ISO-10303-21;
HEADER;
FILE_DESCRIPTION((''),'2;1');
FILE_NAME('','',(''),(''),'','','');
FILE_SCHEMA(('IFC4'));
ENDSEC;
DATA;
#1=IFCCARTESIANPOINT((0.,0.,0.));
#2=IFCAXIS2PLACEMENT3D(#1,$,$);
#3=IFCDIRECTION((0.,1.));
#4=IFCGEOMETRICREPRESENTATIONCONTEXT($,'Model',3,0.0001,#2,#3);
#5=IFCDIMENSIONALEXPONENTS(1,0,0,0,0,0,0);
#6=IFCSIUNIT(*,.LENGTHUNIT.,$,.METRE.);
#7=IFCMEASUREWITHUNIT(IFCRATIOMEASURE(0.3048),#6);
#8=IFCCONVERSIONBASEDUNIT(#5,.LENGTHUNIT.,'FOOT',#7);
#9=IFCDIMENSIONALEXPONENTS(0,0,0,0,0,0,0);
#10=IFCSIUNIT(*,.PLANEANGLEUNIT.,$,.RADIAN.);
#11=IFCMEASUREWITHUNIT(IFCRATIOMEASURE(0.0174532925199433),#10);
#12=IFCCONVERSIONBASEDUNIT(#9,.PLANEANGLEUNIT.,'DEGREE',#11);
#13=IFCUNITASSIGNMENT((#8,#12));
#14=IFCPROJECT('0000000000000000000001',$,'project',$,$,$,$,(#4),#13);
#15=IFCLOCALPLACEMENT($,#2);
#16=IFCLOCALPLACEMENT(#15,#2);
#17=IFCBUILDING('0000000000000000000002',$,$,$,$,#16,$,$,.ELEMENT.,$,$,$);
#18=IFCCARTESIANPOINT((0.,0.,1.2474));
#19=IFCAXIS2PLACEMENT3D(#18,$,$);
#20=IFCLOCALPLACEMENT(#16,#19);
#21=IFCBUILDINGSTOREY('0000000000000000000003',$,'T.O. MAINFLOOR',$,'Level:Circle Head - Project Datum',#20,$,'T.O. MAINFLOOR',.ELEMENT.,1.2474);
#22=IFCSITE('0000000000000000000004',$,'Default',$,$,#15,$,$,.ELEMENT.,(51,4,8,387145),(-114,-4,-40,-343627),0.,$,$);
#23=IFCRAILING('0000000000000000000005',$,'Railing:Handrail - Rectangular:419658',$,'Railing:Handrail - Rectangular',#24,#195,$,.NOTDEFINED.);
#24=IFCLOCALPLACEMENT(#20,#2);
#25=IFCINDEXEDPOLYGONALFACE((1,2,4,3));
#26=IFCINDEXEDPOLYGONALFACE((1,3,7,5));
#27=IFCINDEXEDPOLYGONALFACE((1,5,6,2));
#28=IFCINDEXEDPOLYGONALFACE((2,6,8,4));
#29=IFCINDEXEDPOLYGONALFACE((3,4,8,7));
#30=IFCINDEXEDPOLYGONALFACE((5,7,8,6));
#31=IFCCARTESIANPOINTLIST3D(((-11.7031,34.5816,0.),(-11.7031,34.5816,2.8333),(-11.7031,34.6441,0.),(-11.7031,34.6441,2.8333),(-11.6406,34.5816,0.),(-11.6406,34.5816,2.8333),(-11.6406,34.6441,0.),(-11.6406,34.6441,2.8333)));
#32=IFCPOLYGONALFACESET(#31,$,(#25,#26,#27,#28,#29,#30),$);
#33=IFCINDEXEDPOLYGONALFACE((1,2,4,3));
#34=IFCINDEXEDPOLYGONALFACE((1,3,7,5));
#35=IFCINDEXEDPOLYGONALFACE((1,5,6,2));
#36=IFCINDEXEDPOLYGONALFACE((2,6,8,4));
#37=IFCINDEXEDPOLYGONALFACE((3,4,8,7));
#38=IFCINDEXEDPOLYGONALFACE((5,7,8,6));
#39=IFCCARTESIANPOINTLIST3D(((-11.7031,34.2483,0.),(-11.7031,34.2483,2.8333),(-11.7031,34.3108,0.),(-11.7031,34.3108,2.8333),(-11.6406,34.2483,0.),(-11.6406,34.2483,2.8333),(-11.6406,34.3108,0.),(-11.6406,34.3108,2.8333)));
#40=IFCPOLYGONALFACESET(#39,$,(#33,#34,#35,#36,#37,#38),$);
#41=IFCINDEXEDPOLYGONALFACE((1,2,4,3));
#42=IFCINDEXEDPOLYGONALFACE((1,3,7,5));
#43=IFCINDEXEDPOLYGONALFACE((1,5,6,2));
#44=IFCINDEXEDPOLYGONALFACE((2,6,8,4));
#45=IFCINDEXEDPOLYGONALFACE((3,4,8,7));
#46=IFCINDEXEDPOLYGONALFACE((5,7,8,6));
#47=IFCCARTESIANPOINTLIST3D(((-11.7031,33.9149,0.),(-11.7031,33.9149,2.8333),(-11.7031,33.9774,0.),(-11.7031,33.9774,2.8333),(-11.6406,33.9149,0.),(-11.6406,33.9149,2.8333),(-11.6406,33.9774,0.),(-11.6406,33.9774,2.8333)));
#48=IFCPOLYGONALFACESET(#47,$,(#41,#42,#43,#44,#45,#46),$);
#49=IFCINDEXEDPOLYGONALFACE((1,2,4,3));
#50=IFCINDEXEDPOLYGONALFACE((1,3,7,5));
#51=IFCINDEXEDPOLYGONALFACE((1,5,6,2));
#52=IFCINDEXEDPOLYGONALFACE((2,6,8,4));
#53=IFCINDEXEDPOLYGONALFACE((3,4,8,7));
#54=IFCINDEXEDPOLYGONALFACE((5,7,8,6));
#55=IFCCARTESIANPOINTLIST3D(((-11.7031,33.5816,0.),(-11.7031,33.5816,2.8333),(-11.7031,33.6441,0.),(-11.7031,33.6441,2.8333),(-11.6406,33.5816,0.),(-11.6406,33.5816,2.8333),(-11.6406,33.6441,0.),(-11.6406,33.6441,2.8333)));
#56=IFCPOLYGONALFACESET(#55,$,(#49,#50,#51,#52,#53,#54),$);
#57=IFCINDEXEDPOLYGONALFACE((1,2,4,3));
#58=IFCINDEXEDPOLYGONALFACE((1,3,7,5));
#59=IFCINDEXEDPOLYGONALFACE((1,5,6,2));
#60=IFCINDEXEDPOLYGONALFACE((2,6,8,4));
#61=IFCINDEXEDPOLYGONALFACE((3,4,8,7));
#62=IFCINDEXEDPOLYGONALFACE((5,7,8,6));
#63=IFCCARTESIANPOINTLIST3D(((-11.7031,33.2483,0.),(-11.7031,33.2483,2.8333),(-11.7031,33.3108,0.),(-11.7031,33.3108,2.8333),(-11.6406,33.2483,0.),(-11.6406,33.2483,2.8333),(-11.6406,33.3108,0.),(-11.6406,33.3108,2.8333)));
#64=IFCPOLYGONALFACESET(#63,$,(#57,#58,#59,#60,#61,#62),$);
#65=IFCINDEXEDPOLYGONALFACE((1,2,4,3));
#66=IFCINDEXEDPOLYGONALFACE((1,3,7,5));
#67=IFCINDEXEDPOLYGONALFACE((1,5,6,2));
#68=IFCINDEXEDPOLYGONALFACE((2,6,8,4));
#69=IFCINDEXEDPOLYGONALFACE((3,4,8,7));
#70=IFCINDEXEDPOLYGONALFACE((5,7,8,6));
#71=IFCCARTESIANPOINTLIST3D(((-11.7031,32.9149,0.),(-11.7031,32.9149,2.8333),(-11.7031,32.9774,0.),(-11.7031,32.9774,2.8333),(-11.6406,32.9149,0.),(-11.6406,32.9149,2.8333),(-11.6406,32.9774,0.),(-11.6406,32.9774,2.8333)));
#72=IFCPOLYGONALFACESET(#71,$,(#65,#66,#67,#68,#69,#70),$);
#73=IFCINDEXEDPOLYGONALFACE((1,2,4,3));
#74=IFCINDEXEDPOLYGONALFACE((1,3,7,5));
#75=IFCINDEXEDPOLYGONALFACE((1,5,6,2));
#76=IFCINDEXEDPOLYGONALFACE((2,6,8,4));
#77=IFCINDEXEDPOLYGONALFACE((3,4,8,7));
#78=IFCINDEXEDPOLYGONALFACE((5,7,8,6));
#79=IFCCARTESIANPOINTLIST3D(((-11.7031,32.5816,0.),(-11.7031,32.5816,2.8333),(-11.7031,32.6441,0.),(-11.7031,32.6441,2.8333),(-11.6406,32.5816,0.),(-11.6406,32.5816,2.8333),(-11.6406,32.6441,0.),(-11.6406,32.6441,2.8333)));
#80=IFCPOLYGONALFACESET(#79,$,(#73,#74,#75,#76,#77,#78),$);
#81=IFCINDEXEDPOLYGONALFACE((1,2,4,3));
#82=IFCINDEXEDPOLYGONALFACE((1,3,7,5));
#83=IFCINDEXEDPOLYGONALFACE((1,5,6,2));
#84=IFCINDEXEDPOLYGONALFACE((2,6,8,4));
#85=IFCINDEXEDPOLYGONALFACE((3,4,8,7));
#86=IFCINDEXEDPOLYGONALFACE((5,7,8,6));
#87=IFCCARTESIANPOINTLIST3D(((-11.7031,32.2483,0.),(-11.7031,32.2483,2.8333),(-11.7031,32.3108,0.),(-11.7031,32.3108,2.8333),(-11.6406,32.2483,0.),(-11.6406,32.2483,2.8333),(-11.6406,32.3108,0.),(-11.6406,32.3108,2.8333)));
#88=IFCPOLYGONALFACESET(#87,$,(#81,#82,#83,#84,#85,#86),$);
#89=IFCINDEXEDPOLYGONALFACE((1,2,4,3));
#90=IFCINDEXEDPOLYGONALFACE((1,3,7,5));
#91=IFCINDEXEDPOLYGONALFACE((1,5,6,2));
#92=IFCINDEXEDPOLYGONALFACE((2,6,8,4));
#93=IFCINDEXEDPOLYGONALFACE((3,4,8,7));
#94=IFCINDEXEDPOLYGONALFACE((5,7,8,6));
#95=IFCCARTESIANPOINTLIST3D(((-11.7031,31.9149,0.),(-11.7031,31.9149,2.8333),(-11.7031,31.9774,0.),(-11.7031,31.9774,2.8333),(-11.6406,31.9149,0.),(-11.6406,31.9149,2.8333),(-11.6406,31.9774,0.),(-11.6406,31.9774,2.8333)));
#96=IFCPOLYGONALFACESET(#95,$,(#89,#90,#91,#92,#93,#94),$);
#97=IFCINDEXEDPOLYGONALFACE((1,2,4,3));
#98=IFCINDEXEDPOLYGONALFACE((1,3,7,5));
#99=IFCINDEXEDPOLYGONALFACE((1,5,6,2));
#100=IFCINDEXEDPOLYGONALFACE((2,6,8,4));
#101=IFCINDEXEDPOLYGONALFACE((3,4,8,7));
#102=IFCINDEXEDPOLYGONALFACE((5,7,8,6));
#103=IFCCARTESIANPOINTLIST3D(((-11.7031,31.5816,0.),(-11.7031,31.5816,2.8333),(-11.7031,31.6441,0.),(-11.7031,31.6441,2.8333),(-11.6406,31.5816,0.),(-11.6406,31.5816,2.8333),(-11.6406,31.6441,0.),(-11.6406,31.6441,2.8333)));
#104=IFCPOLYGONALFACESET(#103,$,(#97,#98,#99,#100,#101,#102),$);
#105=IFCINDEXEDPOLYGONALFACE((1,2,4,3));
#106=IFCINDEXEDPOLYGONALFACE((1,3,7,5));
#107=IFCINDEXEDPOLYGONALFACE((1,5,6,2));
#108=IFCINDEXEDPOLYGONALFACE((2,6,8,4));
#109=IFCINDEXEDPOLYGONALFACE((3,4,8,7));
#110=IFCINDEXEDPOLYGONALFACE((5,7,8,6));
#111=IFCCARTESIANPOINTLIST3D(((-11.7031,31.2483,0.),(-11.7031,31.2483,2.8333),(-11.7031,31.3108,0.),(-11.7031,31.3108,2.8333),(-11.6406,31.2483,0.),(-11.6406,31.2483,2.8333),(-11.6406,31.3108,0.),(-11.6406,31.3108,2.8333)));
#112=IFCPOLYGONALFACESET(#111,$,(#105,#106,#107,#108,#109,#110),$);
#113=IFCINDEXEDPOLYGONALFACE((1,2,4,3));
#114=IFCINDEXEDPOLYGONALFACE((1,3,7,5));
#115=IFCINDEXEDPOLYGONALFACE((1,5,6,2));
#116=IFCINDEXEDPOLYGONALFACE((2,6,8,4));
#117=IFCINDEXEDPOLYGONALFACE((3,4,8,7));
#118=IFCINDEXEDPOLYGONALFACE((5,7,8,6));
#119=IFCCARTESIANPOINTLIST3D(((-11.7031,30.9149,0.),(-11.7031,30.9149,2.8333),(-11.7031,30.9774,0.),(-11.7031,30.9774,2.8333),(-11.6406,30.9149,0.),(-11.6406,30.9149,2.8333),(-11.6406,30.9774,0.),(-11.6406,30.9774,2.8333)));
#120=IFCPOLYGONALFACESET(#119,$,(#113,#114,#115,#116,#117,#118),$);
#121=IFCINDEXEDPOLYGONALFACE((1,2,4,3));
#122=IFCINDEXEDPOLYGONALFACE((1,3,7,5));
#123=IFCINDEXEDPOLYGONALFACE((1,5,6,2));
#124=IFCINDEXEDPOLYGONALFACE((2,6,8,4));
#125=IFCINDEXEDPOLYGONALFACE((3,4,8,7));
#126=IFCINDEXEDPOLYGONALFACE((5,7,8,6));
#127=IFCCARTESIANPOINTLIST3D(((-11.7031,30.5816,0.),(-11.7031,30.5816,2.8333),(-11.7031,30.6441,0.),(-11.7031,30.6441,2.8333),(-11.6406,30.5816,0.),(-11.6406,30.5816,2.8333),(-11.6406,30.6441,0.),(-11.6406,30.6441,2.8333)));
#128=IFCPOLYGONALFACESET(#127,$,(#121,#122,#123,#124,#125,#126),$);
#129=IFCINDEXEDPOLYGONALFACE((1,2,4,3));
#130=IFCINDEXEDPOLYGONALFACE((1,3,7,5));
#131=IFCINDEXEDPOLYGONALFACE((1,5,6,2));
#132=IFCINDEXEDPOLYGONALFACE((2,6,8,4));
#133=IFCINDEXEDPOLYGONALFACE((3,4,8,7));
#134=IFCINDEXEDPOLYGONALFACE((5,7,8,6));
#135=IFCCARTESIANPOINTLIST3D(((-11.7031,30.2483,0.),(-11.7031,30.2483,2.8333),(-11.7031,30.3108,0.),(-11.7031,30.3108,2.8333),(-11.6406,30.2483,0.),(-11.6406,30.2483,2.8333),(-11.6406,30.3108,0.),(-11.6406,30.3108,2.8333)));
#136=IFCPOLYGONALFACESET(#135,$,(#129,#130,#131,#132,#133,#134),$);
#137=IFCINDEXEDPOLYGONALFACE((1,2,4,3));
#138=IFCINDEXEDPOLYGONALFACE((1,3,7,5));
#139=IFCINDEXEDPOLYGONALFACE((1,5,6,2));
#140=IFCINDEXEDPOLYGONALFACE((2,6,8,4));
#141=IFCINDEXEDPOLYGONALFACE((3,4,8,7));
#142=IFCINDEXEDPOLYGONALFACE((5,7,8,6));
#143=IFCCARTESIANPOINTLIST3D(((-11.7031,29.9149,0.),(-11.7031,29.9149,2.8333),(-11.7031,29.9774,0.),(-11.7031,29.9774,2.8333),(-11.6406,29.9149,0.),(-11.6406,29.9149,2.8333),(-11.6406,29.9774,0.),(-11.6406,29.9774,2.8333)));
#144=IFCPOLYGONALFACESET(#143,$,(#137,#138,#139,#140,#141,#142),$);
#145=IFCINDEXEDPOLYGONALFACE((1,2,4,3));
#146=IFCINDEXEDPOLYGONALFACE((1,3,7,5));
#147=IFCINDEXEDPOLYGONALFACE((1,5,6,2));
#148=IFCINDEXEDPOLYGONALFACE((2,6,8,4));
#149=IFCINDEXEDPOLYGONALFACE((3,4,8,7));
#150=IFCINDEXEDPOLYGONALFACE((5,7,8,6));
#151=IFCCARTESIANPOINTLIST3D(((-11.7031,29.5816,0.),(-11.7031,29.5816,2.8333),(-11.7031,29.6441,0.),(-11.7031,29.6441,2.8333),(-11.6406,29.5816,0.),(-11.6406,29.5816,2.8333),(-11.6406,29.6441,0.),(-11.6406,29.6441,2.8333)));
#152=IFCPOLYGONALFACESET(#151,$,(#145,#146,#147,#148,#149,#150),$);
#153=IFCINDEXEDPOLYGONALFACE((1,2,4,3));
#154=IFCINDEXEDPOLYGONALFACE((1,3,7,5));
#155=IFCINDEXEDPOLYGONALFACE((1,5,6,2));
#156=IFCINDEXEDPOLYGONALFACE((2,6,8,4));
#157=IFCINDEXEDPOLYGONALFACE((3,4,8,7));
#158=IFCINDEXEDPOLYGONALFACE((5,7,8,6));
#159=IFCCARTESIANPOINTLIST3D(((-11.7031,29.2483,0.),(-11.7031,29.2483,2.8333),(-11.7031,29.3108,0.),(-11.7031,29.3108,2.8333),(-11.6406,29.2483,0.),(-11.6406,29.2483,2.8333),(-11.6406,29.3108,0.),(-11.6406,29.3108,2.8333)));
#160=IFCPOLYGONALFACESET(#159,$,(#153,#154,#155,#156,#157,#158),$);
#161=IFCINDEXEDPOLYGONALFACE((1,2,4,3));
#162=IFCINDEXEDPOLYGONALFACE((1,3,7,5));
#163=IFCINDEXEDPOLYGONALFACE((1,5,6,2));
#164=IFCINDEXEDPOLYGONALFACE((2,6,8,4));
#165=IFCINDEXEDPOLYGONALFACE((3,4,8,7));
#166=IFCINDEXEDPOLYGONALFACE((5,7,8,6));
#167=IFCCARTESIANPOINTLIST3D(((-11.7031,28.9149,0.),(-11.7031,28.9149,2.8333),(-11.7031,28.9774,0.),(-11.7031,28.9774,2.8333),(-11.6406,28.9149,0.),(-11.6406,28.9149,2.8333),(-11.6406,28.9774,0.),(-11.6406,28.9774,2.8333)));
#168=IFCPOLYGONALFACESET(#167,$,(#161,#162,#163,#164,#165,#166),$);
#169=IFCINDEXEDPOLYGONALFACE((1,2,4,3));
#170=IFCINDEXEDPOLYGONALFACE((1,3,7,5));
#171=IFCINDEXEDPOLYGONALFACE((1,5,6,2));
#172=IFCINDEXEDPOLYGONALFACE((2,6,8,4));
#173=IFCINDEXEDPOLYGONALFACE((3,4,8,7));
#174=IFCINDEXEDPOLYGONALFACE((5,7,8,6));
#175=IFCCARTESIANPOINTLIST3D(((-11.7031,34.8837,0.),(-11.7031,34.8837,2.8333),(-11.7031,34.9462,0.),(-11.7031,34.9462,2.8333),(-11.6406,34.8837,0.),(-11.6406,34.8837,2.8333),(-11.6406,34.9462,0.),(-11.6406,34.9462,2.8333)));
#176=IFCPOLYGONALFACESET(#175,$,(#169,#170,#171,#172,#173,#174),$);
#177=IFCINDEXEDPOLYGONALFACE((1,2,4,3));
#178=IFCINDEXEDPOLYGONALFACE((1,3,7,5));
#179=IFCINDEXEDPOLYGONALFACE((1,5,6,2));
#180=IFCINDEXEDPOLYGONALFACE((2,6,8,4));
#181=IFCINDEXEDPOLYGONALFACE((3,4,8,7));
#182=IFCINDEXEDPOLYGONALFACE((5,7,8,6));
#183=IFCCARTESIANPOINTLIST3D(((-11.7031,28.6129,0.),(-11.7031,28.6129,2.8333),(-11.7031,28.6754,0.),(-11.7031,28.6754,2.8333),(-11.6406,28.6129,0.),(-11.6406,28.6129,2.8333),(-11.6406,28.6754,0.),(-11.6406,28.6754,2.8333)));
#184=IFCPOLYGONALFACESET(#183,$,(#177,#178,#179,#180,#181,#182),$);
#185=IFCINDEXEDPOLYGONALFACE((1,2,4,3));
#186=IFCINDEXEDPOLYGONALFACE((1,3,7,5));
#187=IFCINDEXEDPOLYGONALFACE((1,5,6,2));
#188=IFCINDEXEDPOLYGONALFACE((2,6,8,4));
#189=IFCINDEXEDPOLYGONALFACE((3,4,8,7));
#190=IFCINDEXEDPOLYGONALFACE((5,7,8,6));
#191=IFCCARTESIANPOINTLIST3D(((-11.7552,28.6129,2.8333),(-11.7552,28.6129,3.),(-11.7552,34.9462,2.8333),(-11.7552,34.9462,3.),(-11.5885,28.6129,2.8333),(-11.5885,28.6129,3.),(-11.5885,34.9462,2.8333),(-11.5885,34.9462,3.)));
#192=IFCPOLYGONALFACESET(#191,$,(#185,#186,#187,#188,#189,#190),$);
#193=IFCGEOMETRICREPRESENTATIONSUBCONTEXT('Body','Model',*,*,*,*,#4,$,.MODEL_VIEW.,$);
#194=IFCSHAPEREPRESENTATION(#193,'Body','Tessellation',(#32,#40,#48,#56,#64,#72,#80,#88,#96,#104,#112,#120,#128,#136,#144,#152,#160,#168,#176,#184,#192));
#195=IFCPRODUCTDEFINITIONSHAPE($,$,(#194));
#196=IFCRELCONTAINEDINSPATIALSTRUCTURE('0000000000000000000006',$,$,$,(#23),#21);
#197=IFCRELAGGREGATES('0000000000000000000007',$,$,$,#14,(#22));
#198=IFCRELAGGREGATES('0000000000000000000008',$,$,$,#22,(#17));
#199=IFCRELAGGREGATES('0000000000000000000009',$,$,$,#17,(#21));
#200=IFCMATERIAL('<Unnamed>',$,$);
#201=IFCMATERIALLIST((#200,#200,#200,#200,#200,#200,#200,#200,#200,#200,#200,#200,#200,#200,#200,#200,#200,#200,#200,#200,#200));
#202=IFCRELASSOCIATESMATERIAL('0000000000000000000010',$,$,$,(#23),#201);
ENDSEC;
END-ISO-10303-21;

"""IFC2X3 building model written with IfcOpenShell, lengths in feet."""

from ifc_helpers import new_model, entity, si_unit, converted_unit, direction, frame, origin, origin_2d_with_axis, place, context, subcontext, project, spatial, rectangle, extrude, material, material_list, element, save


model = new_model("IFC2X3")

# Units and contexts
model_context = context("Model", 3, precision=0.0001, world=origin(), true_north=direction((0.0, 1.0)))
body_context = subcontext(model_context, "Body", "Model", "MODEL_VIEW")
ifc_project = project(units=[converted_unit("LENGTHUNIT", "FOOT", entity("IfcRatioMeasure", 0.3048), si_unit("LENGTHUNIT", "METRE"), dimensions=[1, 0, 0, 0, 0, 0, 0]), converted_unit("PLANEANGLEUNIT", "DEGREE", entity("IfcRatioMeasure", 0.0174532925199433), si_unit("PLANEANGLEUNIT", "RADIAN"), dimensions=[0, 0, 0, 0, 0, 0, 0])], contexts=[model_context])

# Site, building, storey
site_placement = place(None, origin())
site = spatial("IfcSite", under=ifc_project, at=site_placement, Name="Default", CompositionType="ELEMENT", RefLatitude=(51, 4, 8, 387145), RefLongitude=(-114, -4, -40, -343627), RefElevation=0.0)
building_placement = place(site_placement, origin())
building = spatial("IfcBuilding", under=site, at=building_placement, CompositionType="ELEMENT")
storey_placement = place(building_placement, frame((0.0, 0.0, 1.2474)))
storey = spatial("IfcBuildingStorey", under=building, at=storey_placement, Name="T.O. MAINFLOOR", ObjectType="Level:Circle Head - Project Datum", LongName="T.O. MAINFLOOR", CompositionType="ELEMENT", Elevation=1.2474)

# Shared definitions
ifc_material_1 = material(Name="<Unnamed>")

# Railing
ifc_material_list_1 = material_list([ifc_material_1, ifc_material_1, ifc_material_1, ifc_material_1, ifc_material_1, ifc_material_1, ifc_material_1, ifc_material_1, ifc_material_1, ifc_material_1, ifc_material_1, ifc_material_1, ifc_material_1, ifc_material_1, ifc_material_1, ifc_material_1, ifc_material_1, ifc_material_1, ifc_material_1, ifc_material_1, ifc_material_1])
railing_placement = place(storey_placement, origin())
element("IfcRailing", 1, at=railing_placement, inside=storey, material=ifc_material_list_1, Name="Railing:Handrail - Rectangular:419658", ObjectType="Railing:Handrail - Rectangular", PredefinedType="NOTDEFINED", context=body_context, shape_type="SweptSolid", body=[
    extrude(rectangle(XDim=0.0625, YDim=0.0625, at=origin_2d_with_axis()), frame((-11.6719, 34.6129, 0.0), z_axis=(0.0, 0.0, 1.0), x_axis=(0.0, 1.0, 0.0)), (0.0, 0.0, 1.0), 2.8333),
    extrude(rectangle(XDim=0.0625, YDim=0.0625, at=origin_2d_with_axis()), frame((-11.6719, 34.2795, 0.0), z_axis=(0.0, 0.0, 1.0), x_axis=(0.0, 1.0, 0.0)), (0.0, 0.0, 1.0), 2.8333),
    extrude(rectangle(XDim=0.0625, YDim=0.0625, at=origin_2d_with_axis()), frame((-11.6719, 33.9462, 0.0), z_axis=(0.0, 0.0, 1.0), x_axis=(0.0, 1.0, 0.0)), (0.0, 0.0, 1.0), 2.8333),
    extrude(rectangle(XDim=0.0625, YDim=0.0625, at=origin_2d_with_axis()), frame((-11.6719, 33.6129, 0.0), z_axis=(0.0, 0.0, 1.0), x_axis=(0.0, 1.0, 0.0)), (0.0, 0.0, 1.0), 2.8333),
    extrude(rectangle(XDim=0.0625, YDim=0.0625, at=origin_2d_with_axis()), frame((-11.6719, 33.2795, 0.0), z_axis=(0.0, 0.0, 1.0), x_axis=(0.0, 1.0, 0.0)), (0.0, 0.0, 1.0), 2.8333),
    extrude(rectangle(XDim=0.0625, YDim=0.0625, at=origin_2d_with_axis()), frame((-11.6719, 32.9462, 0.0), z_axis=(0.0, 0.0, 1.0), x_axis=(0.0, 1.0, 0.0)), (0.0, 0.0, 1.0), 2.8333),
    extrude(rectangle(XDim=0.0625, YDim=0.0625, at=origin_2d_with_axis()), frame((-11.6719, 32.6129, 0.0), z_axis=(0.0, 0.0, 1.0), x_axis=(0.0, 1.0, 0.0)), (0.0, 0.0, 1.0), 2.8333),
    extrude(rectangle(XDim=0.0625, YDim=0.0625, at=origin_2d_with_axis()), frame((-11.6719, 32.2795, 0.0), z_axis=(0.0, 0.0, 1.0), x_axis=(0.0, 1.0, 0.0)), (0.0, 0.0, 1.0), 2.8333),
    extrude(rectangle(XDim=0.0625, YDim=0.0625, at=origin_2d_with_axis()), frame((-11.6719, 31.9462, 0.0), z_axis=(0.0, 0.0, 1.0), x_axis=(0.0, 1.0, 0.0)), (0.0, 0.0, 1.0), 2.8333),
    extrude(rectangle(XDim=0.0625, YDim=0.0625, at=origin_2d_with_axis()), frame((-11.6719, 31.6129, 0.0), z_axis=(0.0, 0.0, 1.0), x_axis=(0.0, 1.0, 0.0)), (0.0, 0.0, 1.0), 2.8333),
    extrude(rectangle(XDim=0.0625, YDim=0.0625, at=origin_2d_with_axis()), frame((-11.6719, 31.2795, 0.0), z_axis=(0.0, 0.0, 1.0), x_axis=(0.0, 1.0, 0.0)), (0.0, 0.0, 1.0), 2.8333),
    extrude(rectangle(XDim=0.0625, YDim=0.0625, at=origin_2d_with_axis()), frame((-11.6719, 30.9462, 0.0), z_axis=(0.0, 0.0, 1.0), x_axis=(0.0, 1.0, 0.0)), (0.0, 0.0, 1.0), 2.8333),
    extrude(rectangle(XDim=0.0625, YDim=0.0625, at=origin_2d_with_axis()), frame((-11.6719, 30.6129, 0.0), z_axis=(0.0, 0.0, 1.0), x_axis=(0.0, 1.0, 0.0)), (0.0, 0.0, 1.0), 2.8333),
    extrude(rectangle(XDim=0.0625, YDim=0.0625, at=origin_2d_with_axis()), frame((-11.6719, 30.2795, 0.0), z_axis=(0.0, 0.0, 1.0), x_axis=(0.0, 1.0, 0.0)), (0.0, 0.0, 1.0), 2.8333),
    extrude(rectangle(XDim=0.0625, YDim=0.0625, at=origin_2d_with_axis()), frame((-11.6719, 29.9462, 0.0), z_axis=(0.0, 0.0, 1.0), x_axis=(0.0, 1.0, 0.0)), (0.0, 0.0, 1.0), 2.8333),
    extrude(rectangle(XDim=0.0625, YDim=0.0625, at=origin_2d_with_axis()), frame((-11.6719, 29.6129, 0.0), z_axis=(0.0, 0.0, 1.0), x_axis=(0.0, 1.0, 0.0)), (0.0, 0.0, 1.0), 2.8333),
    extrude(rectangle(XDim=0.0625, YDim=0.0625, at=origin_2d_with_axis()), frame((-11.6719, 29.2795, 0.0), z_axis=(0.0, 0.0, 1.0), x_axis=(0.0, 1.0, 0.0)), (0.0, 0.0, 1.0), 2.8333),
    extrude(rectangle(XDim=0.0625, YDim=0.0625, at=origin_2d_with_axis()), frame((-11.6719, 28.9462, 0.0), z_axis=(0.0, 0.0, 1.0), x_axis=(0.0, 1.0, 0.0)), (0.0, 0.0, 1.0), 2.8333),
    extrude(rectangle(XDim=0.0625, YDim=0.0625, at=origin_2d_with_axis()), frame((-11.6719, 34.9149, 0.0), z_axis=(0.0, 0.0, 1.0), x_axis=(0.0, 1.0, 0.0)), (0.0, 0.0, 1.0), 2.8333),
    extrude(rectangle(XDim=0.0625, YDim=0.0625, at=origin_2d_with_axis()), frame((-11.6719, 28.6441, 0.0), z_axis=(0.0, 0.0, 1.0), x_axis=(0.0, 1.0, 0.0)), (0.0, 0.0, 1.0), 2.8333),
    extrude(rectangle(XDim=6.3333, YDim=0.1667, at=origin_2d_with_axis()), frame((-11.6719, 31.7795, 2.8333), z_axis=(0.0, 0.0, 1.0), x_axis=(0.0, 1.0, 0.0)), (0.0, 0.0, 1.0), 0.1667),
])

save(model, "model.ifc")
